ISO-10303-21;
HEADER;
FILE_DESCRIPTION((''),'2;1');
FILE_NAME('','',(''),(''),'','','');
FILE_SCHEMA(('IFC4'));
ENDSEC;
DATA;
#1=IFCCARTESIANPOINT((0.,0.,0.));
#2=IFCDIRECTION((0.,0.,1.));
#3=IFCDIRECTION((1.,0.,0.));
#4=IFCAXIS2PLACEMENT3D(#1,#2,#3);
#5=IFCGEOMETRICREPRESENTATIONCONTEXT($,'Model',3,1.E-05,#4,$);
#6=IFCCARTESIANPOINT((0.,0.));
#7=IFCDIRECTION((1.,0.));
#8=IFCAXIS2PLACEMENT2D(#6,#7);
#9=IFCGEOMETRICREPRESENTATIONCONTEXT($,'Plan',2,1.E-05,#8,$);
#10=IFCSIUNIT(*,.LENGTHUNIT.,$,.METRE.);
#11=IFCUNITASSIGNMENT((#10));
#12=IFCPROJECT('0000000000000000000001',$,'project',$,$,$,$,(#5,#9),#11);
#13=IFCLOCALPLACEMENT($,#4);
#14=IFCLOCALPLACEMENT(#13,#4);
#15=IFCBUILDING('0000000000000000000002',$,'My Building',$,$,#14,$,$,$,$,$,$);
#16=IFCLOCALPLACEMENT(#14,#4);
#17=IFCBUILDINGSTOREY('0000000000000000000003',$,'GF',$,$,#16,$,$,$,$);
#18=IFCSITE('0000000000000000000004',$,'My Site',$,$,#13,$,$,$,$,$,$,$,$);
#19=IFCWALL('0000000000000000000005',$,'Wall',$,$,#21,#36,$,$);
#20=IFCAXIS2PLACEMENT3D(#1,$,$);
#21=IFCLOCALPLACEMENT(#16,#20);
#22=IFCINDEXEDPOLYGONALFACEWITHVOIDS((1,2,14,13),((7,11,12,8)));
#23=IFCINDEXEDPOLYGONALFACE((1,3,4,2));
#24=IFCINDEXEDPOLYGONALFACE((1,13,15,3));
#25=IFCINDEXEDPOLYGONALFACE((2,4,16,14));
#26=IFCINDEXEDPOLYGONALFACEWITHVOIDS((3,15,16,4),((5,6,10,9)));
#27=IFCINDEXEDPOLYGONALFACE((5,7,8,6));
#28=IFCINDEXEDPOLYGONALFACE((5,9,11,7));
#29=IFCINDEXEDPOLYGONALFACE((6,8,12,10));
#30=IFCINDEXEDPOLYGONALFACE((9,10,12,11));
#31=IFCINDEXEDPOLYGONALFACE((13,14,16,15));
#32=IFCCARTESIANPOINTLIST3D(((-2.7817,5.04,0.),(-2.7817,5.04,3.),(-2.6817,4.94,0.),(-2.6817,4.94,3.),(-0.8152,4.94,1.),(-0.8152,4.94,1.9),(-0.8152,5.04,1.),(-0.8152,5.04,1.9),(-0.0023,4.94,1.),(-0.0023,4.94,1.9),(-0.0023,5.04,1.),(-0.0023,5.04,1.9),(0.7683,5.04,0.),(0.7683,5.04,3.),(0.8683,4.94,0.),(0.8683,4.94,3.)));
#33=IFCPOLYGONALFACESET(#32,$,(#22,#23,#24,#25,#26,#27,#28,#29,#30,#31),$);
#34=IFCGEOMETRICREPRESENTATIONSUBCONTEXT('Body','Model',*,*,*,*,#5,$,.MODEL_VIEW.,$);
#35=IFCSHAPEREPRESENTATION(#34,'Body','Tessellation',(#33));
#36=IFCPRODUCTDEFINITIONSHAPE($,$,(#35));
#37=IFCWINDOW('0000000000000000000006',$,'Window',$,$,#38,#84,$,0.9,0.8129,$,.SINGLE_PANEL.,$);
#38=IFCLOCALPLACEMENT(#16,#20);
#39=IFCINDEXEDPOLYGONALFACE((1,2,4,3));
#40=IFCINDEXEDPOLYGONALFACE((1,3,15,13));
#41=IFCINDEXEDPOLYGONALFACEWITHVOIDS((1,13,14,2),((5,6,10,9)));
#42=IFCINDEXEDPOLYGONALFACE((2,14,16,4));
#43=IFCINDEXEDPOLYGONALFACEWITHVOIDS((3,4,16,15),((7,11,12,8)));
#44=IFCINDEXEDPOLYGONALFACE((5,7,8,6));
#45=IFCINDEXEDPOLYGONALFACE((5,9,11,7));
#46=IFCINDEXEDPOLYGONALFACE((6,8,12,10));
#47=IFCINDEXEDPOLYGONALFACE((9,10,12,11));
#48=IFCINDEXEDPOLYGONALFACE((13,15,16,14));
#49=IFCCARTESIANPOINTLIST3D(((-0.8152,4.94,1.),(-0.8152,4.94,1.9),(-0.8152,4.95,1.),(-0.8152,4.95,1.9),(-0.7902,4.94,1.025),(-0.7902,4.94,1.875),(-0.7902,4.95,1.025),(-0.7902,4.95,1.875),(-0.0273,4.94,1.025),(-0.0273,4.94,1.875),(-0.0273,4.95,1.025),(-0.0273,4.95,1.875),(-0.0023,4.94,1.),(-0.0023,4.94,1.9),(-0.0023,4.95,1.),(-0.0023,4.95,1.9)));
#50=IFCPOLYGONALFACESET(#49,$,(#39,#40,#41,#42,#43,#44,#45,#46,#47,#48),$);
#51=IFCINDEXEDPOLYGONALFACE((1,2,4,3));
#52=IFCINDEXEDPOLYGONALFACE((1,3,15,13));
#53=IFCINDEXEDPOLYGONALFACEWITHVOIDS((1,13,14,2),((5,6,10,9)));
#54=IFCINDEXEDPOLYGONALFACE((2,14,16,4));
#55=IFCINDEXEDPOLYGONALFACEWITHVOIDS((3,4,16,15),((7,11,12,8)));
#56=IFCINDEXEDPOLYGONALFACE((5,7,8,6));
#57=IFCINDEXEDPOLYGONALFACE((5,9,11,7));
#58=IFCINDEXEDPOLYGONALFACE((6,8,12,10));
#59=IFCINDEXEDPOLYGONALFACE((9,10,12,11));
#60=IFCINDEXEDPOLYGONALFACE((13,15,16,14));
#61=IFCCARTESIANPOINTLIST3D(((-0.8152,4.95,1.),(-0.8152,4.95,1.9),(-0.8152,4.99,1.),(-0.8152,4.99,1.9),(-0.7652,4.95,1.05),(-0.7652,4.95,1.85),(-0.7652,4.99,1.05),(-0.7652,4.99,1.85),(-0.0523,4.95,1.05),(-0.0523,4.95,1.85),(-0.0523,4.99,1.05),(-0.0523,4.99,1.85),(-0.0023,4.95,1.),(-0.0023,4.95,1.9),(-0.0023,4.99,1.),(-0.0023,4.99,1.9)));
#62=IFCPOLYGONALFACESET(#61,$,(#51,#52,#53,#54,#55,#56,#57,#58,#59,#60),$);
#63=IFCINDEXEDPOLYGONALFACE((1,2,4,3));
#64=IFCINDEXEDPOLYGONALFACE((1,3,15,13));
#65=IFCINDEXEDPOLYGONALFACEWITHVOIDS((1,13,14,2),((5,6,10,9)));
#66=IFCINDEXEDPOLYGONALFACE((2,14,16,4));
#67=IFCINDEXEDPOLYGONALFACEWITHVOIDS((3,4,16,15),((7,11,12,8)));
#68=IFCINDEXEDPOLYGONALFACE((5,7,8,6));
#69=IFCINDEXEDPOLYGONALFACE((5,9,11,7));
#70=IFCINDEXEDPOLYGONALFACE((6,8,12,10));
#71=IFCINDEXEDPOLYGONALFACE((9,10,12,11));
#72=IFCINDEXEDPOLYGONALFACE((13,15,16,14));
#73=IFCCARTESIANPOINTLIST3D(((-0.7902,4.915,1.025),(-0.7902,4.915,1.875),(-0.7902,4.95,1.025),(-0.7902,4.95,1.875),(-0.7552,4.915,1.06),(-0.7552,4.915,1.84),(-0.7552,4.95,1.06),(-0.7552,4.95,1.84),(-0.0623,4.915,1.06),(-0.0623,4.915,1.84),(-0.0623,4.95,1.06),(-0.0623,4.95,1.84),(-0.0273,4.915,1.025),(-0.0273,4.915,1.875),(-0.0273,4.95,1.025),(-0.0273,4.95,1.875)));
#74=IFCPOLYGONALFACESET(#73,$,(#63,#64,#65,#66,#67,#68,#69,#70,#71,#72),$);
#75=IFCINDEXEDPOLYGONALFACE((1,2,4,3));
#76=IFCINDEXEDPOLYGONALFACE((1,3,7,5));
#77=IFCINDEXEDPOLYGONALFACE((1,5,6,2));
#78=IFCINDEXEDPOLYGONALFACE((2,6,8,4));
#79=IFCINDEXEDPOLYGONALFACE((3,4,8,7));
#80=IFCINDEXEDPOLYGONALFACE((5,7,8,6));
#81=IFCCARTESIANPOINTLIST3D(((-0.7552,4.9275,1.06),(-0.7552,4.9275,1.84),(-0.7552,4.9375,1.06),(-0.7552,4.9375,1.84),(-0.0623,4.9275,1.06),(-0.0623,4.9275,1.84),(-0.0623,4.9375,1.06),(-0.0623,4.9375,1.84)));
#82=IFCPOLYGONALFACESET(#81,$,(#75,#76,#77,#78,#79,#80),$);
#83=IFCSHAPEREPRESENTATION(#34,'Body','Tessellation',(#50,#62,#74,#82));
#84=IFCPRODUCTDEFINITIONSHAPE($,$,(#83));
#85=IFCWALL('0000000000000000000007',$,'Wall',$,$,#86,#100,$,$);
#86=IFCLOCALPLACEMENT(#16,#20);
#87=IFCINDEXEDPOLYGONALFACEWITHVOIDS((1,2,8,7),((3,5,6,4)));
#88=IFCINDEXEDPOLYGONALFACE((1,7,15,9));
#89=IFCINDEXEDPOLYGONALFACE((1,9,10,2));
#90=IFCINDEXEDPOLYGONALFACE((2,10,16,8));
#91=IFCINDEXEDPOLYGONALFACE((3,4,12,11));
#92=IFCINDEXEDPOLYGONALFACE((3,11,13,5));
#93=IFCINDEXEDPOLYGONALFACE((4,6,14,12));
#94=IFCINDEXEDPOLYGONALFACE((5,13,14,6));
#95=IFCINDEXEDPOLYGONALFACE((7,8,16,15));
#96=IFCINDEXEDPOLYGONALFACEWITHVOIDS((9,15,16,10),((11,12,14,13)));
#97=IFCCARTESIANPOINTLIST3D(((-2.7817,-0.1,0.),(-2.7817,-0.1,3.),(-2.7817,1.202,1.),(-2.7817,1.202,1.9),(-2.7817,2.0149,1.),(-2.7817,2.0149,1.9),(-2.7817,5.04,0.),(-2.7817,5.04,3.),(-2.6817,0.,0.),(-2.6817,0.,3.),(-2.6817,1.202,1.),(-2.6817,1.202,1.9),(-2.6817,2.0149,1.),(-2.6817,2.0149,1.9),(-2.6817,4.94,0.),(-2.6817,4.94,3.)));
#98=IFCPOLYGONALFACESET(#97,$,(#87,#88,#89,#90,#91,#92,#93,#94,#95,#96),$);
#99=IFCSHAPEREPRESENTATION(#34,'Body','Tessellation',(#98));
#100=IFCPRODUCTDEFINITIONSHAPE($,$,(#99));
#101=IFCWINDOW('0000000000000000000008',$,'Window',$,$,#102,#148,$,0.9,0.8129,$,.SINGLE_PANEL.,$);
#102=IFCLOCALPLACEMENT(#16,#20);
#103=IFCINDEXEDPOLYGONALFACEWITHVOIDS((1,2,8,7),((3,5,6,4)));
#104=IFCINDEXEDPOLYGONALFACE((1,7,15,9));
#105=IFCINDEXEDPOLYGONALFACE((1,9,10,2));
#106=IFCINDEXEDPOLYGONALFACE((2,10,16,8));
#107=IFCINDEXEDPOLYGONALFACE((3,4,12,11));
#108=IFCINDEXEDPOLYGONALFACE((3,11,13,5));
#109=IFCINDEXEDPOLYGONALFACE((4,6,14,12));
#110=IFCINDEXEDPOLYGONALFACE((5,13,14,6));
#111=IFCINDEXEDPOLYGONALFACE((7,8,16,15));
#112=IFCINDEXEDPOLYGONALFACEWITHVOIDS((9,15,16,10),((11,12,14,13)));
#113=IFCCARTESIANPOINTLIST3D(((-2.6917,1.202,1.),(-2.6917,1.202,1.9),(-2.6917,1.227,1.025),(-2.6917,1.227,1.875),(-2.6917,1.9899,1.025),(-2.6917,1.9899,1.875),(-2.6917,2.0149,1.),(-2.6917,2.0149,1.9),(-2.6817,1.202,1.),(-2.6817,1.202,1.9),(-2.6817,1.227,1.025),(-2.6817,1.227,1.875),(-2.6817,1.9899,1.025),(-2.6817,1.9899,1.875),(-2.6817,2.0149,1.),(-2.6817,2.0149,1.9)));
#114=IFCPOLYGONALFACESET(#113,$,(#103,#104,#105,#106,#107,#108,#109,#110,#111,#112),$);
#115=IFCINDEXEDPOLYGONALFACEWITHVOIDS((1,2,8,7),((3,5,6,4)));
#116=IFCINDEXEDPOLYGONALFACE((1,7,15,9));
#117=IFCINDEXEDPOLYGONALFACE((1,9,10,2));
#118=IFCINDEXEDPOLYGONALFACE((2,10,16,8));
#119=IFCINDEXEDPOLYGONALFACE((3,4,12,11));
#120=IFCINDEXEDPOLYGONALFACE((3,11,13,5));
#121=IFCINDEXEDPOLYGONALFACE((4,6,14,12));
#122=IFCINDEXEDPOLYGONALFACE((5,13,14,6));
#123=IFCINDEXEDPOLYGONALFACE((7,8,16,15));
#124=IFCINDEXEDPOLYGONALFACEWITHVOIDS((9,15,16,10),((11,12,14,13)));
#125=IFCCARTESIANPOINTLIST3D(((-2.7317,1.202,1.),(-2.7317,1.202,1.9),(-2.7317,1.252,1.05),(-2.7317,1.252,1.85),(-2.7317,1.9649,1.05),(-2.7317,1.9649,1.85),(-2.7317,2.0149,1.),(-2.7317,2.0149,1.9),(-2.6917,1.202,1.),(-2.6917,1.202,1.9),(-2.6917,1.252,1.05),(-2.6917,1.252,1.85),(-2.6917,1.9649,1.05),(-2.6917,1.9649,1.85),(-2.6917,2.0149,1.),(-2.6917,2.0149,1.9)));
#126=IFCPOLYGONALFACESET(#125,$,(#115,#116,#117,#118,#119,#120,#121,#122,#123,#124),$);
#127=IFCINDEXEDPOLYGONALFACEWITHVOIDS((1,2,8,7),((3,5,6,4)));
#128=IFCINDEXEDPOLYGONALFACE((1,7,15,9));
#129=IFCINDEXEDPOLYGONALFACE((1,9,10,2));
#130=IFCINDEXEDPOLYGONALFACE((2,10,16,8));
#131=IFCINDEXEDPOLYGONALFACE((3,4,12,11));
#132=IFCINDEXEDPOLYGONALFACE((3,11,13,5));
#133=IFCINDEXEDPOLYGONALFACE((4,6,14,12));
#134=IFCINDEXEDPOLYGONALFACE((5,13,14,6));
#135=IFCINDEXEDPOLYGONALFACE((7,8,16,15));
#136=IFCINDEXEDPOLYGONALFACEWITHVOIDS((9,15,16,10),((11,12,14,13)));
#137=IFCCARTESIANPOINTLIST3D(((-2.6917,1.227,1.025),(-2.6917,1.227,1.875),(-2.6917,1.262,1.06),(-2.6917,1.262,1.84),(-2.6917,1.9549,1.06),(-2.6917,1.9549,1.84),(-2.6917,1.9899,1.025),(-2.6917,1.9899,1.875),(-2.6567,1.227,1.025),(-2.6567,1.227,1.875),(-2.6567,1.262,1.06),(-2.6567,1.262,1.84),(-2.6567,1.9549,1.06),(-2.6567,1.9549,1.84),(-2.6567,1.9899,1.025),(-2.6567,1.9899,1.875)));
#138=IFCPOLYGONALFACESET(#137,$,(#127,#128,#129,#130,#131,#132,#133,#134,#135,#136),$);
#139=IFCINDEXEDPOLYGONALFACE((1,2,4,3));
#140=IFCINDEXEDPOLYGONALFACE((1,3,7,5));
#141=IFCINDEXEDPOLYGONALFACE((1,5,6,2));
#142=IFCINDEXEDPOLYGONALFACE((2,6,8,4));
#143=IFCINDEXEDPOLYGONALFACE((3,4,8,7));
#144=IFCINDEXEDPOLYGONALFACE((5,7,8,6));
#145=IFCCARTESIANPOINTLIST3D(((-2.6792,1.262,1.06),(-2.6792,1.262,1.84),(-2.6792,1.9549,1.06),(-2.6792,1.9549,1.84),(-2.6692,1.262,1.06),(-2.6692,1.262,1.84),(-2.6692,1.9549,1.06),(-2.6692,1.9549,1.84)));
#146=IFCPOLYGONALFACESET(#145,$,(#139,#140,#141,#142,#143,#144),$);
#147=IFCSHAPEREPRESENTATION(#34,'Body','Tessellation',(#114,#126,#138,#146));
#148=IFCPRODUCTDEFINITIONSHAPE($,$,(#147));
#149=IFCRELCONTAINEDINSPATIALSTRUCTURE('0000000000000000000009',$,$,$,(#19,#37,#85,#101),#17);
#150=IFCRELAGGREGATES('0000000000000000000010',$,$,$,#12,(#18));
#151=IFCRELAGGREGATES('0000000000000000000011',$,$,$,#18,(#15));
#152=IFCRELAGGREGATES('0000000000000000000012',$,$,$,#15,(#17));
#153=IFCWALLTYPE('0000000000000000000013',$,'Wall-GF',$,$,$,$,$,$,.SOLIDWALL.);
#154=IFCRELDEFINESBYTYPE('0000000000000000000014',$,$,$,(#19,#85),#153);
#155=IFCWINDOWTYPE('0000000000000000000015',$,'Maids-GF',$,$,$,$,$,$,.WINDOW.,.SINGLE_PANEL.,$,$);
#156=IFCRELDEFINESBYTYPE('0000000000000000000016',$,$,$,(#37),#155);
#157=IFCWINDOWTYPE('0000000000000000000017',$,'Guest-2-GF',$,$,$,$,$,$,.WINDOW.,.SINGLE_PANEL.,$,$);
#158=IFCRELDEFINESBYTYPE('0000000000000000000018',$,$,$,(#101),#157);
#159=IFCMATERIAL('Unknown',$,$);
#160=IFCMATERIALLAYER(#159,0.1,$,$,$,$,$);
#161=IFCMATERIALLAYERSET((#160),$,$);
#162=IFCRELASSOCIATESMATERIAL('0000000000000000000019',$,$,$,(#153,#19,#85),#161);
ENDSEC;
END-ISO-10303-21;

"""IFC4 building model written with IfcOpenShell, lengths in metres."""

from ifc_helpers import new_model, entity, si_unit, frame, origin_with_axes, origin_2d_with_axis, place, context, subcontext, project, spatial, line, indexed_curve, outline, extrude, shape, source, transform, mapped, material, layer, layer_set, layer_usage, type_object, type_shapes, element, fill, save


model = new_model("IFC4")

# Units and contexts
model_context = context("Model", 3, precision=1e-05, world=origin_with_axes())
plan_context = context("Plan", 2, precision=1e-05, world=origin_2d_with_axis())
body_context_1 = subcontext(model_context, "Body", "Model", "MODEL_VIEW")
body_context_2 = subcontext(plan_context, "Body", "Plan", "PLAN_VIEW")
ifc_project = project(units=[si_unit("LENGTHUNIT", "METRE")], contexts=[model_context, plan_context])

# Site, building, storey
site_placement = place(None, origin_with_axes())
site = spatial("IfcSite", under=ifc_project, at=site_placement, Name="My Site")
building_placement = place(site_placement, origin_with_axes())
building = spatial("IfcBuilding", under=site, at=building_placement, Name="My Building")
storey_placement = place(building_placement, origin_with_axes())
storey = spatial("IfcBuildingStorey", under=building, at=storey_placement, Name="GF")

# Shared definitions
ifc_material_1 = material(Name="Unknown")

# Shared definitions
ifc_layer_1 = layer(ifc_material_1, 0.1)
ifc_layer_set_1 = layer_set([ifc_layer_1])
wall_type = type_object("IfcWallType", Name="Wall-GF", PredefinedType="SOLIDWALL", material=ifc_layer_set_1)

# Walls, openings, windows
ifc_layer_usage_1 = layer_usage(ifc_layer_set_1, "AXIS2", "POSITIVE", 0.0)
wall_1_placement = place(storey_placement, frame((0.7683, 5.04, 0.0), z_axis=(0.0, 0.0, 1.0), x_axis=(-1.0, 0.0, 0.0)))
wall_1 = element("IfcWall", 1, at=wall_1_placement, inside=storey, type_object=wall_type, material=ifc_layer_usage_1, Name="Wall", context=body_context_1, shape_type="SweptSolid", body=[
    extrude(outline(indexed_curve([(0.0, 0.0), (-0.1, 0.1), (3.45, 0.1), (3.55, 0.0)], segments=[line(1, 2, 3, 4, 1)])), origin_with_axes(), (0.0, 0.0, 1.0), 3.0),
])
shared_shape_1 = source(origin_with_axes(), body_context_1, "Body", "SweptSolid", [
    extrude(outline(indexed_curve([(0.0, 0.0), (0.8129, 0.0), (0.8129, 0.9), (0.0, 0.9)], segments=[line(1, 2, 3, 4, 1)])), frame((0.0, -0.6, 0.0), z_axis=(0.0, -1.0, 0.0), x_axis=(1.0, 0.0, 0.0)), (0.0, 0.0, -1.0), 1.2),
])
opening_1_placement = place(wall_1_placement, frame((0.7707, 0.0, 1.0), z_axis=(0.0, 0.0, 1.0), x_axis=(1.0, 0.0, 0.0)))
opening_1 = element("IfcOpeningElement", 2, at=opening_1_placement, cuts=wall_1, PredefinedType="OPENING", context=body_context_1, shape_type="MappedRepresentation", body=[
    mapped(shared_shape_1, transform((0.0, 0.0, 0.0), x_axis=(1.0, 0.0, 0.0), y_axis=(0.0, 1.0, 0.0), z_axis=(0.0, 0.0, 1.0), scale=1.0)),
])
window_type_1 = type_object("IfcWindowType", Name="Maids-GF", PartitioningType="SINGLE_PANEL", PredefinedType="WINDOW")
shared_shape_2 = source(origin_with_axes(), body_context_1, "Body", "SweptSolid", [
    extrude(outline(indexed_curve([(0.0, 0.0), (0.8129, 0.0), (0.8129, 0.9), (0.0, 0.9)], segments=[line(1, 2, 3, 4, 1)]), holes=[indexed_curve([(0.025, 0.025), (0.7879, 0.025), (0.7879, 0.875), (0.025, 0.875)], segments=[line(1, 2, 3, 4, 1)])]), frame((0.0, 0.09, 0.0), z_axis=(0.0, -1.0, 0.0), x_axis=(1.0, 0.0, 0.0)), (0.0, 0.0, -1.0), 0.01),
    extrude(outline(indexed_curve([(0.0, 0.0), (0.8129, 0.0), (0.8129, 0.9), (0.0, 0.9)], segments=[line(1, 2, 3, 4, 1)]), holes=[indexed_curve([(0.05, 0.05), (0.7629, 0.05), (0.7629, 0.85), (0.05, 0.85)], segments=[line(1, 2, 3, 4, 1)])]), frame((0.0, 0.05, 0.0), z_axis=(0.0, -1.0, 0.0), x_axis=(1.0, 0.0, 0.0)), (0.0, 0.0, -1.0), 0.04),
    extrude(outline(indexed_curve([(0.0, 0.0), (0.7629, 0.0), (0.7629, 0.85), (0.0, 0.85)], segments=[line(1, 2, 3, 4, 1)]), holes=[indexed_curve([(0.035, 0.035), (0.7279, 0.035), (0.7279, 0.815), (0.035, 0.815)], segments=[line(1, 2, 3, 4, 1)])]), frame((0.025, 0.09, 0.025), z_axis=(0.0, -1.0, 0.0), x_axis=(1.0, 0.0, 0.0)), (0.0, 0.0, -1.0), 0.035),
    extrude(outline(indexed_curve([(0.035, 0.035), (0.7279, 0.035), (0.7279, 0.815), (0.035, 0.815)], segments=[line(1, 2, 3, 4, 1)])), frame((0.025, 0.1025, 0.025), z_axis=(0.0, -1.0, 0.0), x_axis=(1.0, 0.0, 0.0)), (0.0, 0.0, -1.0), 0.01),
])
shared_shape_3 = source(origin_with_axes(), body_context_2, "Body", "Curve2D", [
    entity("IfcIndexedPolyCurve", entity("IfcCartesianPointList2D", [[0.05, 0.05], [0.7629, 0.05]])),
    entity("IfcIndexedPolyCurve", entity("IfcCartesianPointList2D", [[0.0, 0.1], [0.025, 0.1], [0.025, 0.09], [0.05, 0.09], [0.05, 0.05], [0.0, 0.05]]), [entity("IfcLineIndex", [1, 2, 3, 4, 5, 6, 1])]),
    entity("IfcIndexedPolyCurve", entity("IfcCartesianPointList2D", [[0.8129, 0.1], [0.7879, 0.1], [0.7879, 0.09], [0.7629, 0.09], [0.7629, 0.05], [0.8129, 0.05]]), [entity("IfcLineIndex", [1, 2, 3, 4, 5, 6, 1])]),
    entity("IfcIndexedPolyCurve", entity("IfcCartesianPointList2D", [[0.025, 0.09], [0.06, 0.09], [0.06, 0.125], [0.025, 0.125]]), [entity("IfcLineIndex", [1, 2, 3, 4, 1])]),
    entity("IfcIndexedPolyCurve", entity("IfcCartesianPointList2D", [[0.7879, 0.09], [0.7529, 0.09], [0.7529, 0.125], [0.7879, 0.125]]), [entity("IfcLineIndex", [1, 2, 3, 4, 1])]),
    entity("IfcIndexedPolyCurve", entity("IfcCartesianPointList2D", [[0.06, 0.09], [0.7529, 0.09]])),
    entity("IfcIndexedPolyCurve", entity("IfcCartesianPointList2D", [[0.06, 0.125], [0.7529, 0.125]])),
    entity("IfcIndexedPolyCurve", entity("IfcCartesianPointList2D", [[0.06, 0.1075], [0.7529, 0.1075]])),
])
type_shapes(window_type_1, [shared_shape_2, shared_shape_3])
window_1_placement = place(opening_1_placement, frame((0.0, 0.0, 0.0), z_axis=(0.0, 0.0, 1.0), x_axis=(1.0, 0.0, 0.0)))
window_1 = element("IfcWindow", 3, at=window_1_placement, inside=storey, type_object=window_type_1, Name="Window", OverallHeight=0.9, OverallWidth=0.8129, PartitioningType="SINGLE_PANEL", shapes=[
    shape(body_context_1, "Body", "MappedRepresentation", [mapped(shared_shape_2, transform((0.0, 0.0, 0.0), x_axis=(1.0, 0.0, 0.0), y_axis=(0.0, 1.0, 0.0), z_axis=(0.0, 0.0, 1.0), scale=1.0))]),
    shape(body_context_2, "Body", "MappedRepresentation", [mapped(shared_shape_3, transform((0.0, 0.0, 0.0), x_axis=(1.0, 0.0, 0.0), y_axis=(0.0, 1.0, 0.0), z_axis=(0.0, 0.0, 1.0), scale=1.0))]),
])
fill(opening_1, window_1)
ifc_layer_usage_2 = layer_usage(ifc_layer_set_1, "AXIS2", "POSITIVE", 0.0)
wall_2_placement = place(storey_placement, frame((-2.7817, 5.04, 0.0), z_axis=(0.0, 0.0, 1.0), x_axis=(0.0, -1.0, 0.0)))
wall_2 = element("IfcWall", 4, at=wall_2_placement, inside=storey, type_object=wall_type, material=ifc_layer_usage_2, Name="Wall", context=body_context_1, shape_type="SweptSolid", body=[
    extrude(outline(indexed_curve([(0.0, 0.0), (0.1, 0.1), (5.04, 0.1), (5.14, 0.0)], segments=[line(1, 2, 3, 4, 1)])), origin_with_axes(), (0.0, 0.0, 1.0), 3.0),
])
shared_shape_4 = source(origin_with_axes(), body_context_1, "Body", "SweptSolid", [
    extrude(outline(indexed_curve([(0.0, 0.0), (0.8129, 0.0), (0.8129, 0.9), (0.0, 0.9)], segments=[line(1, 2, 3, 4, 1)])), frame((0.0, -0.6, 0.0), z_axis=(0.0, -1.0, 0.0), x_axis=(1.0, 0.0, 0.0)), (0.0, 0.0, -1.0), 1.2),
])
opening_2_placement = place(wall_2_placement, frame((3.0251, 0.0, 1.0), z_axis=(0.0, 0.0, 1.0), x_axis=(1.0, 0.0, 0.0)))
opening_2 = element("IfcOpeningElement", 5, at=opening_2_placement, cuts=wall_2, PredefinedType="OPENING", context=body_context_1, shape_type="MappedRepresentation", body=[
    mapped(shared_shape_4, transform((0.0, 0.0, 0.0), x_axis=(1.0, 0.0, 0.0), y_axis=(0.0, 1.0, 0.0), z_axis=(0.0, 0.0, 1.0), scale=1.0)),
])
window_type_2 = type_object("IfcWindowType", Name="Guest-2-GF", PartitioningType="SINGLE_PANEL", PredefinedType="WINDOW")
shared_shape_5 = source(origin_with_axes(), body_context_1, "Body", "SweptSolid", [
    extrude(outline(indexed_curve([(0.0, 0.0), (0.8129, 0.0), (0.8129, 0.9), (0.0, 0.9)], segments=[line(1, 2, 3, 4, 1)]), holes=[indexed_curve([(0.025, 0.025), (0.7879, 0.025), (0.7879, 0.875), (0.025, 0.875)], segments=[line(1, 2, 3, 4, 1)])]), frame((0.0, 0.09, 0.0), z_axis=(0.0, -1.0, 0.0), x_axis=(1.0, 0.0, 0.0)), (0.0, 0.0, -1.0), 0.01),
    extrude(outline(indexed_curve([(0.0, 0.0), (0.8129, 0.0), (0.8129, 0.9), (0.0, 0.9)], segments=[line(1, 2, 3, 4, 1)]), holes=[indexed_curve([(0.05, 0.05), (0.7629, 0.05), (0.7629, 0.85), (0.05, 0.85)], segments=[line(1, 2, 3, 4, 1)])]), frame((0.0, 0.05, 0.0), z_axis=(0.0, -1.0, 0.0), x_axis=(1.0, 0.0, 0.0)), (0.0, 0.0, -1.0), 0.04),
    extrude(outline(indexed_curve([(0.0, 0.0), (0.7629, 0.0), (0.7629, 0.85), (0.0, 0.85)], segments=[line(1, 2, 3, 4, 1)]), holes=[indexed_curve([(0.035, 0.035), (0.7279, 0.035), (0.7279, 0.815), (0.035, 0.815)], segments=[line(1, 2, 3, 4, 1)])]), frame((0.025, 0.09, 0.025), z_axis=(0.0, -1.0, 0.0), x_axis=(1.0, 0.0, 0.0)), (0.0, 0.0, -1.0), 0.035),
    extrude(outline(indexed_curve([(0.035, 0.035), (0.7279, 0.035), (0.7279, 0.815), (0.035, 0.815)], segments=[line(1, 2, 3, 4, 1)])), frame((0.025, 0.1025, 0.025), z_axis=(0.0, -1.0, 0.0), x_axis=(1.0, 0.0, 0.0)), (0.0, 0.0, -1.0), 0.01),
])
shared_shape_6 = source(origin_with_axes(), body_context_2, "Body", "Curve2D", [
    entity("IfcIndexedPolyCurve", entity("IfcCartesianPointList2D", [[0.05, 0.05], [0.7629, 0.05]])),
    entity("IfcIndexedPolyCurve", entity("IfcCartesianPointList2D", [[0.0, 0.1], [0.025, 0.1], [0.025, 0.09], [0.05, 0.09], [0.05, 0.05], [0.0, 0.05]]), [entity("IfcLineIndex", [1, 2, 3, 4, 5, 6, 1])]),
    entity("IfcIndexedPolyCurve", entity("IfcCartesianPointList2D", [[0.8129, 0.1], [0.7879, 0.1], [0.7879, 0.09], [0.7629, 0.09], [0.7629, 0.05], [0.8129, 0.05]]), [entity("IfcLineIndex", [1, 2, 3, 4, 5, 6, 1])]),
    entity("IfcIndexedPolyCurve", entity("IfcCartesianPointList2D", [[0.025, 0.09], [0.06, 0.09], [0.06, 0.125], [0.025, 0.125]]), [entity("IfcLineIndex", [1, 2, 3, 4, 1])]),
    entity("IfcIndexedPolyCurve", entity("IfcCartesianPointList2D", [[0.7879, 0.09], [0.7529, 0.09], [0.7529, 0.125], [0.7879, 0.125]]), [entity("IfcLineIndex", [1, 2, 3, 4, 1])]),
    entity("IfcIndexedPolyCurve", entity("IfcCartesianPointList2D", [[0.06, 0.09], [0.7529, 0.09]])),
    entity("IfcIndexedPolyCurve", entity("IfcCartesianPointList2D", [[0.06, 0.125], [0.7529, 0.125]])),
    entity("IfcIndexedPolyCurve", entity("IfcCartesianPointList2D", [[0.06, 0.1075], [0.7529, 0.1075]])),
])
type_shapes(window_type_2, [shared_shape_5, shared_shape_6])
window_2_placement = place(opening_2_placement, frame((0.0, 0.0, 0.0), z_axis=(0.0, 0.0, 1.0), x_axis=(1.0, 0.0, 0.0)))
window_2 = element("IfcWindow", 6, at=window_2_placement, inside=storey, type_object=window_type_2, Name="Window", OverallHeight=0.9, OverallWidth=0.8129, PartitioningType="SINGLE_PANEL", shapes=[
    shape(body_context_1, "Body", "MappedRepresentation", [mapped(shared_shape_5, transform((0.0, 0.0, 0.0), x_axis=(1.0, 0.0, 0.0), y_axis=(0.0, 1.0, 0.0), z_axis=(0.0, 0.0, 1.0), scale=1.0))]),
    shape(body_context_2, "Body", "MappedRepresentation", [mapped(shared_shape_6, transform((0.0, 0.0, 0.0), x_axis=(1.0, 0.0, 0.0), y_axis=(0.0, 1.0, 0.0), z_axis=(0.0, 0.0, 1.0), scale=1.0))]),
])
fill(opening_2, window_2)

save(model, "model.ifc")
